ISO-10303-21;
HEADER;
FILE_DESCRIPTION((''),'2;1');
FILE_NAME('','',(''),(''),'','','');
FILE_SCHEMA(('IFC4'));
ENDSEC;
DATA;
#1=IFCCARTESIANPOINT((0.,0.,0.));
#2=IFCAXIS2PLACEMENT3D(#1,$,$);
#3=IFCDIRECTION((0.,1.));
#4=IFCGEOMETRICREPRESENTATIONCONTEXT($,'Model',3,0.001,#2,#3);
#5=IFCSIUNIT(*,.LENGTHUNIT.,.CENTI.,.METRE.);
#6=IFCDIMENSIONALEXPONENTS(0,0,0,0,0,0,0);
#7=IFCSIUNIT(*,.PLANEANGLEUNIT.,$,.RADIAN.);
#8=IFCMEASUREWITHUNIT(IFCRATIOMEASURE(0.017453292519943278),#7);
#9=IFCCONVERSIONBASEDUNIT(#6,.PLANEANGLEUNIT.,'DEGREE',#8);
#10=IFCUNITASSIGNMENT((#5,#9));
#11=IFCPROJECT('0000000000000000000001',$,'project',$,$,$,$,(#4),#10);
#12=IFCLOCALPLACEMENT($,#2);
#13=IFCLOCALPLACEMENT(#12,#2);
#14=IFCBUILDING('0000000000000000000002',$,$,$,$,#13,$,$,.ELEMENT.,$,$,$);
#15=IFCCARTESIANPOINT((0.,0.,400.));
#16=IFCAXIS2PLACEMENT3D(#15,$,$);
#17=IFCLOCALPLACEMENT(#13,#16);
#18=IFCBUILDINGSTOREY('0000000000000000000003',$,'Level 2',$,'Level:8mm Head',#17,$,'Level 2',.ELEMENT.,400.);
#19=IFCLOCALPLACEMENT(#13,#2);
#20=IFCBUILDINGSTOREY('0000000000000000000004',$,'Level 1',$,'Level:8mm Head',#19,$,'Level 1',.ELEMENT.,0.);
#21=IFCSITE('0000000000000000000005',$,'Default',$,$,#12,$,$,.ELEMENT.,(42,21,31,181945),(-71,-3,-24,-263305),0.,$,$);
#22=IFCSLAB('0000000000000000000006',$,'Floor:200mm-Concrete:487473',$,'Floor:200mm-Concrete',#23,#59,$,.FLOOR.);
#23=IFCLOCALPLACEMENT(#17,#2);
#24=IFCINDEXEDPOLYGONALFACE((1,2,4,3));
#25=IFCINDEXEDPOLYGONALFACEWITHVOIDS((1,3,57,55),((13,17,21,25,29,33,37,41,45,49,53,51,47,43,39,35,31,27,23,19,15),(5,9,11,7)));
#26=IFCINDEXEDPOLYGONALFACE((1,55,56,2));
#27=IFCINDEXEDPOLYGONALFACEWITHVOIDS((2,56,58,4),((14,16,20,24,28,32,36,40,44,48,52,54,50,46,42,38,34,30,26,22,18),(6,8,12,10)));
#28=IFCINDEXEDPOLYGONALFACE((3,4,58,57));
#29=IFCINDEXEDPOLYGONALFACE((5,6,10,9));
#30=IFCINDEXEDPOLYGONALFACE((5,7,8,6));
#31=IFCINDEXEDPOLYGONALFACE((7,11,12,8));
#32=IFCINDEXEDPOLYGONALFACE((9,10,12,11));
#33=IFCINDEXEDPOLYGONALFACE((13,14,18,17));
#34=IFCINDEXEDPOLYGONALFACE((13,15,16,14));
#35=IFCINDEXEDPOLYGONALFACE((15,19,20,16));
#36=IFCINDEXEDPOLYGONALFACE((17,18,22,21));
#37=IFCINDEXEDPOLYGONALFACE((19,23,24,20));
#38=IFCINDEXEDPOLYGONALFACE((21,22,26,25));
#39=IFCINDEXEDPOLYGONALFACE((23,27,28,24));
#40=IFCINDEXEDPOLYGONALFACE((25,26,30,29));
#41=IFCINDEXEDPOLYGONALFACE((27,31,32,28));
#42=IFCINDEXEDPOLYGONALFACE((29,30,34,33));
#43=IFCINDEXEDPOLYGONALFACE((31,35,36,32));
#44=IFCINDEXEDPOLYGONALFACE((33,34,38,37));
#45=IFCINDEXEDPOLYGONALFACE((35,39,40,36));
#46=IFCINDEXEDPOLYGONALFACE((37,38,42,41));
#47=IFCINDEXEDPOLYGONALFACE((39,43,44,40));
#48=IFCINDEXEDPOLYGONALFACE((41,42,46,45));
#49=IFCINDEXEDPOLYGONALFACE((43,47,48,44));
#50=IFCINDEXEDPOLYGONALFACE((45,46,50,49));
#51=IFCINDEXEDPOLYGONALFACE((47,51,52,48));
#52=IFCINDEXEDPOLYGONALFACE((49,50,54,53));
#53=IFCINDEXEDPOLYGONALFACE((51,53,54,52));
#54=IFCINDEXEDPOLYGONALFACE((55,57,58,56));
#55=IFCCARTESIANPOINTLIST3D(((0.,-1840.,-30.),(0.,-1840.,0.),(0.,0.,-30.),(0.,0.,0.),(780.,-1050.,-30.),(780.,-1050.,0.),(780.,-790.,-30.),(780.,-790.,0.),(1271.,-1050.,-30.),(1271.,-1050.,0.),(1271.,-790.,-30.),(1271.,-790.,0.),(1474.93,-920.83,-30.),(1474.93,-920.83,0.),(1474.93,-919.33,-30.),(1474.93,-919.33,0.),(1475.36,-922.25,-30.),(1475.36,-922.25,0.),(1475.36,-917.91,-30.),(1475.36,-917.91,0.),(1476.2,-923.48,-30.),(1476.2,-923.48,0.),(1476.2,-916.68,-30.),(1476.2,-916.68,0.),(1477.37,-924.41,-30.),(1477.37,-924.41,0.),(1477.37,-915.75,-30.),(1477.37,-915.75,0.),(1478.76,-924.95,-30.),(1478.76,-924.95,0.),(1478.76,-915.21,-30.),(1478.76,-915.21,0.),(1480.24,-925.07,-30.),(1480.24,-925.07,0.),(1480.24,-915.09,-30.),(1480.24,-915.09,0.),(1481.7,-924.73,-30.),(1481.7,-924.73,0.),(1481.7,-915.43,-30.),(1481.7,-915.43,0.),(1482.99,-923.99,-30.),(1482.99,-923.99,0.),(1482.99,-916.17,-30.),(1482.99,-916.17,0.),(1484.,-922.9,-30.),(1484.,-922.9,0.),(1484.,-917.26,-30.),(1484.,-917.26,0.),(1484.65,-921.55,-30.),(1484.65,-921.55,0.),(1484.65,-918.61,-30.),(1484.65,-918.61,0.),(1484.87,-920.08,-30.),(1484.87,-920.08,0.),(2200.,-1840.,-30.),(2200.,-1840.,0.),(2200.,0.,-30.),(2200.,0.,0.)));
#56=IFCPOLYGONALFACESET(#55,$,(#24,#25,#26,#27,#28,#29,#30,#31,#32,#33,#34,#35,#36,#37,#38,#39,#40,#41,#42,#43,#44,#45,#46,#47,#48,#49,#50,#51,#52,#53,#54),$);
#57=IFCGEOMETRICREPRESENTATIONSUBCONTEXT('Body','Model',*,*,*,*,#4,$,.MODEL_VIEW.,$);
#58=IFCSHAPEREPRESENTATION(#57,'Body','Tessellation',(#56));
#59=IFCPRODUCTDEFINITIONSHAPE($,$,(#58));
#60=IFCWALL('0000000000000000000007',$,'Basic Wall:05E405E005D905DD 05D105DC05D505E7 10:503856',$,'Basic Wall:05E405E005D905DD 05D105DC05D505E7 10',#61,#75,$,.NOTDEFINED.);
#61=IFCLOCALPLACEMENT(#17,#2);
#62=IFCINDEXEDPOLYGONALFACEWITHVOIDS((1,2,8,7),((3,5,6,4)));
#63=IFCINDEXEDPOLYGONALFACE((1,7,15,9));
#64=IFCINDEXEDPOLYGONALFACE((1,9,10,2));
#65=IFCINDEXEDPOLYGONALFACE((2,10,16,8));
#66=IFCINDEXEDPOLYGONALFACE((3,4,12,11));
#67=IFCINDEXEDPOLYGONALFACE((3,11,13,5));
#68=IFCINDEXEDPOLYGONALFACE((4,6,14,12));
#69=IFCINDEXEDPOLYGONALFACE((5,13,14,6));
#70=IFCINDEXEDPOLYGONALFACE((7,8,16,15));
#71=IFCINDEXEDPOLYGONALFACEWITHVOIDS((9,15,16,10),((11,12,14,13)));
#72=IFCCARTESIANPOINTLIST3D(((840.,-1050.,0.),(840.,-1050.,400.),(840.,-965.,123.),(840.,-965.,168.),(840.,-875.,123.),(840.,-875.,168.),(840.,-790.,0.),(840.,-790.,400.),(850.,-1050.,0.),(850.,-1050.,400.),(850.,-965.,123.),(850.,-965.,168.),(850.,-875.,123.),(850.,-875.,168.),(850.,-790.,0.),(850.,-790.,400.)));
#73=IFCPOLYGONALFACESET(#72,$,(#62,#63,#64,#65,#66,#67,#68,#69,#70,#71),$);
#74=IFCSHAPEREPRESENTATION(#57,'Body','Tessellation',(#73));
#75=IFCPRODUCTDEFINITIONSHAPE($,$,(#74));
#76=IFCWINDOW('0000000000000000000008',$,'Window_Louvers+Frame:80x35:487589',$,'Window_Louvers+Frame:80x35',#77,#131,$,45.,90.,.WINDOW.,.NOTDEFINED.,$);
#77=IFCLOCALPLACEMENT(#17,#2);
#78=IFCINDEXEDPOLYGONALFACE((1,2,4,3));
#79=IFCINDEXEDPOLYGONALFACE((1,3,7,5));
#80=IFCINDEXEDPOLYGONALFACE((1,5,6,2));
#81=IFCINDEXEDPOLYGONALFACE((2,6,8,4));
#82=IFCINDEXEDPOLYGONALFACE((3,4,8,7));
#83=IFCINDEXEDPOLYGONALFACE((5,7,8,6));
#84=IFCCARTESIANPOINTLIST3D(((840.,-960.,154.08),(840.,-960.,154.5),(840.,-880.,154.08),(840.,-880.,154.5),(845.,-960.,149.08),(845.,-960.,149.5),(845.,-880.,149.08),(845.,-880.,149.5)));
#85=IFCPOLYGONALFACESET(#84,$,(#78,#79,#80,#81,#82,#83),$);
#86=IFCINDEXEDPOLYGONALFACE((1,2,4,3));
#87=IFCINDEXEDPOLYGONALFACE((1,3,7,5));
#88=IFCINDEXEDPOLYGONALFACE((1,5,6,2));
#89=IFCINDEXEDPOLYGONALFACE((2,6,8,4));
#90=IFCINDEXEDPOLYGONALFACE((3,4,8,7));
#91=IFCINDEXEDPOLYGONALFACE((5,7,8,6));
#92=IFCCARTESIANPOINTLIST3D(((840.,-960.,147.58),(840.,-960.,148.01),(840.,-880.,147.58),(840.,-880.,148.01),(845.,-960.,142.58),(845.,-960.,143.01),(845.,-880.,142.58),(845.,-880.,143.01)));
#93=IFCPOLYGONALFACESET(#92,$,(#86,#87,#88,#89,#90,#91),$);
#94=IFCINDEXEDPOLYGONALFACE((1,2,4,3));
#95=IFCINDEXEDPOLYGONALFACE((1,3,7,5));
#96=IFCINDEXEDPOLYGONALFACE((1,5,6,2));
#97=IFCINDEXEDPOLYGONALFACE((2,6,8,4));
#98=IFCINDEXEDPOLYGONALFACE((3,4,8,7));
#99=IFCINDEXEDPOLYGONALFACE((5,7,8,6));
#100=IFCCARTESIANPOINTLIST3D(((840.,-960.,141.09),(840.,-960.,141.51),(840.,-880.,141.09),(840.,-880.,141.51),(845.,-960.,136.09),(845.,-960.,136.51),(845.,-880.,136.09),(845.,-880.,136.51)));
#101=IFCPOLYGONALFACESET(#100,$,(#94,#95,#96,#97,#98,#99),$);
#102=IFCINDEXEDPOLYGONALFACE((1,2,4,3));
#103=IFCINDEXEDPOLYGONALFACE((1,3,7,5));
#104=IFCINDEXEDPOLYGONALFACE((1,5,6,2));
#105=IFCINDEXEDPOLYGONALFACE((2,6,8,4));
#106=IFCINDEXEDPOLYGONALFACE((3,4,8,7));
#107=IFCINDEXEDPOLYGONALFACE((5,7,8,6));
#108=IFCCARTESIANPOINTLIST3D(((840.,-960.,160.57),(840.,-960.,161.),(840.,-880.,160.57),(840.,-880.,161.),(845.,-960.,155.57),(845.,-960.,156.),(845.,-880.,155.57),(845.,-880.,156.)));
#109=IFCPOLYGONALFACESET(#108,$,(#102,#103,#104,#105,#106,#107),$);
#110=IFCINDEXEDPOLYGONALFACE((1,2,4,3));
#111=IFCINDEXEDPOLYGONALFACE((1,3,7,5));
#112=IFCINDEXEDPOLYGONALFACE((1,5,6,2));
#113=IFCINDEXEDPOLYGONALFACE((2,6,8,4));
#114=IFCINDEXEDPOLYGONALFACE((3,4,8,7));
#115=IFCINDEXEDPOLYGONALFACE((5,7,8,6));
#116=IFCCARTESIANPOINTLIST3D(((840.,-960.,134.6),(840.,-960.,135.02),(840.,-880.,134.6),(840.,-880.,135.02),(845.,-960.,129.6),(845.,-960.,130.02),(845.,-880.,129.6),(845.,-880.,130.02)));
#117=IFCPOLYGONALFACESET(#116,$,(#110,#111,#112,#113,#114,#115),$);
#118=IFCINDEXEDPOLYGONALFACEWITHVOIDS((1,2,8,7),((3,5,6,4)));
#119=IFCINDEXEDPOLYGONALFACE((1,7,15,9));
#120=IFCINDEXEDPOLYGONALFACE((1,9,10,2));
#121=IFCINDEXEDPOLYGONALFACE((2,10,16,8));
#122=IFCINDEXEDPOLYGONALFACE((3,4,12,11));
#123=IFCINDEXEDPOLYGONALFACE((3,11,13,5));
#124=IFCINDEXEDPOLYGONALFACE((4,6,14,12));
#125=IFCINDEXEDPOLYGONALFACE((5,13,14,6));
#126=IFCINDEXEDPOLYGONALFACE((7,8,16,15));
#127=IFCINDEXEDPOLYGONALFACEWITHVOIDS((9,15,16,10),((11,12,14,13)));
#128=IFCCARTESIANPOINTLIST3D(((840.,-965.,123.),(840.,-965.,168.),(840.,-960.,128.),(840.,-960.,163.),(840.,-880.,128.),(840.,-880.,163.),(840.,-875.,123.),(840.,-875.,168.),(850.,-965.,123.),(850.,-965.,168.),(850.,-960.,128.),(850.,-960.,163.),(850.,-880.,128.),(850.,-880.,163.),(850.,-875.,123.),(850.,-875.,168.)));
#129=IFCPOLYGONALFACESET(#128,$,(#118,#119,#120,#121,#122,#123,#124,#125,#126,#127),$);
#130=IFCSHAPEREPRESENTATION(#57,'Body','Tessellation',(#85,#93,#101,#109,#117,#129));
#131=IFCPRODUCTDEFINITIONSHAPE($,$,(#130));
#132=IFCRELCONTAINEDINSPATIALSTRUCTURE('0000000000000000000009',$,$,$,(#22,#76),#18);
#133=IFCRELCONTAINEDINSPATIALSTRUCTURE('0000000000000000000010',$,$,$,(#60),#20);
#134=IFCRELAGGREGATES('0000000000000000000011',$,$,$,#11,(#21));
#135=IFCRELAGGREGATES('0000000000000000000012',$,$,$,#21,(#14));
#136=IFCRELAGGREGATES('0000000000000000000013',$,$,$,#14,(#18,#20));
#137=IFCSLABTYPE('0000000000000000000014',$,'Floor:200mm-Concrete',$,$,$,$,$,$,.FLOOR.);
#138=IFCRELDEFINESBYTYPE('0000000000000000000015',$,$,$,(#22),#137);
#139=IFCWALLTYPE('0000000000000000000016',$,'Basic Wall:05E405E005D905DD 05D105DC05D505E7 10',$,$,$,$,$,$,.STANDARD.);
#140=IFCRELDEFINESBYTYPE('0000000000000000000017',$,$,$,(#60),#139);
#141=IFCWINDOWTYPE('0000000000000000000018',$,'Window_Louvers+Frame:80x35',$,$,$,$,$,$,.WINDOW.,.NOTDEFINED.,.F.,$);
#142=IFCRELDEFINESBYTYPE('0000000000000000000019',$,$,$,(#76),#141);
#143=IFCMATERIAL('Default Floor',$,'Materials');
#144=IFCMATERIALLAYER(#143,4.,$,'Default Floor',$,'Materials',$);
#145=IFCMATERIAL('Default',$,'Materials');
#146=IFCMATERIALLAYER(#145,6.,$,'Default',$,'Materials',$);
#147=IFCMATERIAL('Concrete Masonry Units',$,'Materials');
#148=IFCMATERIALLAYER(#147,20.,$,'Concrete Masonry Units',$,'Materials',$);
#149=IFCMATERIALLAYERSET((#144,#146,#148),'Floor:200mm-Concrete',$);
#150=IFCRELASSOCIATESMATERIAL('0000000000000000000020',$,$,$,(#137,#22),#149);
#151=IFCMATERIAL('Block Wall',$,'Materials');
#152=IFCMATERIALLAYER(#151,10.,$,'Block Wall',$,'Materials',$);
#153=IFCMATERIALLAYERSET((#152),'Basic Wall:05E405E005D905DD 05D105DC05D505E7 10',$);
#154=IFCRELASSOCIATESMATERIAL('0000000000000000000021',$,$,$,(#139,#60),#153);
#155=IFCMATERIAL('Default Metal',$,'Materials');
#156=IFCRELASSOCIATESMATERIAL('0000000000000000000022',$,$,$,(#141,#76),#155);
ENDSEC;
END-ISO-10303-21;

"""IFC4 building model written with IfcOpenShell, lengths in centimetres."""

from ifc_helpers import new_model, entity, si_unit, converted_unit, direction, frame, frame_2d, origin, origin_2d_with_axis, place, context, subcontext, project, spatial, polyline, rectangle, circle, outline, extrude, source, transform, mapped, material, layer, layer_set, layer_usage, type_object, type_shapes, element, fill, save


model = new_model("IFC4")

# Units and contexts
model_context = context("Model", 3, precision=0.001, world=origin(), true_north=direction((0.0, 1.0)))
body_context = subcontext(model_context, "Body", "Model", "MODEL_VIEW")
ifc_project = project(units=[si_unit("LENGTHUNIT", "METRE", prefix="CENTI"), converted_unit("PLANEANGLEUNIT", "DEGREE", entity("IfcRatioMeasure", 0.017453292519943278), si_unit("PLANEANGLEUNIT", "RADIAN"), dimensions=[0, 0, 0, 0, 0, 0, 0])], contexts=[model_context])

# Site, building, storey
site_placement = place(None, origin())
site = spatial("IfcSite", under=ifc_project, at=site_placement, Name="Default", CompositionType="ELEMENT", RefLatitude=(42, 21, 31, 181945), RefLongitude=(-71, -3, -24, -263305), RefElevation=0.0)
building_placement = place(site_placement, origin())
building = spatial("IfcBuilding", under=site, at=building_placement, CompositionType="ELEMENT")
storey_1_placement = place(building_placement, frame((0.0, 0.0, 400.0)))
storey_1 = spatial("IfcBuildingStorey", under=building, at=storey_1_placement, Name="Level 2", ObjectType="Level:8mm Head", LongName="Level 2", CompositionType="ELEMENT", Elevation=400.0)

# Slab, openings
ifc_material_1 = material(Name="Default Floor", Category="Materials")
ifc_layer_1 = layer(ifc_material_1, 4.0, Name="Default Floor", Category="Materials")
ifc_material_2 = material(Name="Default", Category="Materials")
ifc_layer_2 = layer(ifc_material_2, 6.0, Name="Default", Category="Materials")
ifc_material_3 = material(Name="Concrete Masonry Units", Category="Materials")
ifc_layer_3 = layer(ifc_material_3, 20.0, Name="Concrete Masonry Units", Category="Materials")
ifc_layer_set_1 = layer_set([ifc_layer_1, ifc_layer_2, ifc_layer_3], Name="Floor:200mm-Concrete")
ifc_layer_usage_1 = layer_usage(ifc_layer_set_1, "AXIS3", "POSITIVE", 0.0)
slab_type = type_object("IfcSlabType", Name="Floor:200mm-Concrete", PredefinedType="FLOOR", material=ifc_layer_set_1)
slab_placement = place(storey_1_placement, frame((0.0, -1840.0, -30.0)))
slab = element("IfcSlab", 1, at=slab_placement, inside=storey_1, type_object=slab_type, material=ifc_layer_usage_1, Name="Floor:200mm-Concrete:487473", ObjectType="Floor:200mm-Concrete", PredefinedType="FLOOR", context=body_context, shape_type="SweptSolid", body=[
    extrude(rectangle(XDim=1840.0, YDim=2200.0, at=frame_2d((0.0, 0.0), x_axis=(0.0, -1.0))), frame((1100.0, 920.0, 30.0), z_axis=(0.0, 0.0, -1.0), x_axis=(-1.0, 0.0, 0.0)), (0.0, 0.0, 1.0), 30.0),
])
opening_1_placement = place(slab_placement, frame((1025.5, 920.0, 30.0)))
element("IfcOpeningElement", 2, at=opening_1_placement, cuts=slab, ObjectType="Opening", context=body_context, shape_type="SweptSolid", body=[
    extrude(rectangle(XDim=491.0, YDim=260.0, at=origin_2d_with_axis()), frame((0.0, 0.0, 0.0), z_axis=(0.0, 0.0, -1.0), x_axis=(1.0, 0.0, 0.0)), (0.0, 0.0, 1.0), 30.0),
])
opening_2_placement = place(slab_placement, frame((1479.87, 919.92, 30.0)))
element("IfcOpeningElement", 3, at=opening_2_placement, cuts=slab, ObjectType="Opening", context=body_context, shape_type="SweptSolid", body=[
    extrude(circle(Radius=5.0, at=origin_2d_with_axis()), frame((0.0, 0.0, 0.0), z_axis=(0.0, 0.0, -1.0), x_axis=(1.0, 0.0, 0.0)), (0.0, 0.0, 1.0), 30.0),
])

# Shared definitions
storey_2_placement = place(building_placement, origin())
storey_2 = spatial("IfcBuildingStorey", under=building, at=storey_2_placement, Name="Level 1", ObjectType="Level:8mm Head", LongName="Level 1", CompositionType="ELEMENT", Elevation=0.0)

# Wall, opening, window
ifc_material_4 = material(Name="Block Wall", Category="Materials")
ifc_layer_4 = layer(ifc_material_4, 10.0, Name="Block Wall", Category="Materials")
ifc_layer_set_2 = layer_set([ifc_layer_4], Name="Basic Wall:05E405E005D905DD 05D105DC05D505E7 10")
ifc_layer_usage_2 = layer_usage(ifc_layer_set_2, "AXIS2", "NEGATIVE", 5.0)
wall_type = type_object("IfcWallType", Name="Basic Wall:05E405E005D905DD 05D105DC05D505E7 10", PredefinedType="STANDARD", material=ifc_layer_set_2)
wall_placement = place(storey_2_placement, frame((845.0, -790.0, 400.0), z_axis=(0.0, 0.0, 1.0), x_axis=(0.0, -1.0, 0.0)))
wall = element("IfcWall", 4, at=wall_placement, inside=storey_2, type_object=wall_type, material=ifc_layer_usage_2, Name="Basic Wall:05E405E005D905DD 05D105DC05D505E7 10:503856", ObjectType="Basic Wall:05E405E005D905DD 05D105DC05D505E7 10", PredefinedType="NOTDEFINED", context=body_context, shape_type="SweptSolid", body=[
    extrude(rectangle(XDim=260.0, YDim=10.0, at=frame_2d((130.0, 0.0), x_axis=(-1.0, 0.0))), origin(), (0.0, 0.0, 1.0), 400.0),
])
opening_3_placement = place(wall_placement, frame((175.0, 5.0, 123.0)))
opening_3 = element("IfcOpeningElement", 5, at=opening_3_placement, cuts=wall, PredefinedType="OPENING", context=body_context, shape_type="SweptSolid", body=[
    extrude(rectangle(XDim=45.0, YDim=90.0, at=frame_2d((22.5, 45.0), x_axis=(-1.0, 0.0))), frame((0.0, 0.0, 0.0), z_axis=(0.0, -1.0, 0.0), x_axis=(0.0, 0.0, 1.0)), (0.0, 0.0, 1.0), 10.0),
])
ifc_material_5 = material(Name="Default Metal", Category="Materials")
window_type = type_object("IfcWindowType", Name="Window_Louvers+Frame:80x35", ParameterTakesPrecedence=False, PartitioningType="NOTDEFINED", PredefinedType="WINDOW", material=ifc_material_5)
shared_shape = source(origin(), body_context, "Body", "SweptSolid", [
    extrude(outline(polyline([(-3.39, -0.15), (3.69, -0.15), (3.39, 0.15), (-3.69, 0.15), (-3.39, -0.15)])), frame((5.0, 2.5, 28.79), z_axis=(1.0, 0.0, 0.0), x_axis=(0.0, -0.707107, 0.707107)), (0.0, 0.0, 1.0), 80.0),
    extrude(outline(polyline([(-3.39, -0.15), (3.69, -0.15), (3.39, 0.15), (-3.69, 0.15), (-3.39, -0.15)])), frame((5.0, 2.5, 22.3), z_axis=(1.0, 0.0, 0.0), x_axis=(0.0, -0.707107, 0.707107)), (0.0, 0.0, 1.0), 80.0),
    extrude(outline(polyline([(-3.39, -0.15), (3.69, -0.15), (3.39, 0.15), (-3.69, 0.15), (-3.39, -0.15)])), frame((5.0, 2.5, 15.8), z_axis=(1.0, 0.0, 0.0), x_axis=(0.0, -0.707107, 0.707107)), (0.0, 0.0, 1.0), 80.0),
    extrude(outline(polyline([(-3.39, -0.15), (3.69, -0.15), (3.39, 0.15), (-3.69, 0.15), (-3.39, -0.15)])), frame((5.0, 2.5, 35.28), z_axis=(1.0, 0.0, 0.0), x_axis=(0.0, -0.707107, 0.707107)), (0.0, 0.0, 1.0), 80.0),
    extrude(outline(polyline([(-3.39, -0.15), (3.69, -0.15), (3.39, 0.15), (-3.69, 0.15), (-3.39, -0.15)])), frame((5.0, 2.5, 9.31), z_axis=(1.0, 0.0, 0.0), x_axis=(0.0, -0.707107, 0.707107)), (0.0, 0.0, 1.0), 80.0),
    extrude(outline(polyline([(-22.5, -45.0), (22.5, -45.0), (22.5, 45.0), (-22.5, 45.0), (-22.5, -45.0)]), holes=[polyline([(17.5, -40.0), (-17.5, -40.0), (-17.5, 40.0), (17.5, 40.0), (17.5, -40.0)])]), frame((45.0, 0.0, 22.5), z_axis=(0.0, 1.0, 0.0), x_axis=(0.0, 0.0, 1.0)), (0.0, 0.0, 1.0), 10.0),
])
type_shapes(window_type, [shared_shape])
window_placement = place(opening_3_placement, frame((-90.0, -10.0, 0.0)))
window = element("IfcWindow", 6, at=window_placement, inside=storey_1, type_object=window_type, material=ifc_material_5, Name="Window_Louvers+Frame:80x35:487589", ObjectType="Window_Louvers+Frame:80x35", OverallHeight=45.0, OverallWidth=90.0, PartitioningType="NOTDEFINED", PredefinedType="WINDOW", context=body_context, shape_type="MappedRepresentation", body=[
    mapped(shared_shape, transform((0.0, 0.0, 0.0), scale=1.0)),
])
fill(opening_3, window)

save(model, "model.ifc")
